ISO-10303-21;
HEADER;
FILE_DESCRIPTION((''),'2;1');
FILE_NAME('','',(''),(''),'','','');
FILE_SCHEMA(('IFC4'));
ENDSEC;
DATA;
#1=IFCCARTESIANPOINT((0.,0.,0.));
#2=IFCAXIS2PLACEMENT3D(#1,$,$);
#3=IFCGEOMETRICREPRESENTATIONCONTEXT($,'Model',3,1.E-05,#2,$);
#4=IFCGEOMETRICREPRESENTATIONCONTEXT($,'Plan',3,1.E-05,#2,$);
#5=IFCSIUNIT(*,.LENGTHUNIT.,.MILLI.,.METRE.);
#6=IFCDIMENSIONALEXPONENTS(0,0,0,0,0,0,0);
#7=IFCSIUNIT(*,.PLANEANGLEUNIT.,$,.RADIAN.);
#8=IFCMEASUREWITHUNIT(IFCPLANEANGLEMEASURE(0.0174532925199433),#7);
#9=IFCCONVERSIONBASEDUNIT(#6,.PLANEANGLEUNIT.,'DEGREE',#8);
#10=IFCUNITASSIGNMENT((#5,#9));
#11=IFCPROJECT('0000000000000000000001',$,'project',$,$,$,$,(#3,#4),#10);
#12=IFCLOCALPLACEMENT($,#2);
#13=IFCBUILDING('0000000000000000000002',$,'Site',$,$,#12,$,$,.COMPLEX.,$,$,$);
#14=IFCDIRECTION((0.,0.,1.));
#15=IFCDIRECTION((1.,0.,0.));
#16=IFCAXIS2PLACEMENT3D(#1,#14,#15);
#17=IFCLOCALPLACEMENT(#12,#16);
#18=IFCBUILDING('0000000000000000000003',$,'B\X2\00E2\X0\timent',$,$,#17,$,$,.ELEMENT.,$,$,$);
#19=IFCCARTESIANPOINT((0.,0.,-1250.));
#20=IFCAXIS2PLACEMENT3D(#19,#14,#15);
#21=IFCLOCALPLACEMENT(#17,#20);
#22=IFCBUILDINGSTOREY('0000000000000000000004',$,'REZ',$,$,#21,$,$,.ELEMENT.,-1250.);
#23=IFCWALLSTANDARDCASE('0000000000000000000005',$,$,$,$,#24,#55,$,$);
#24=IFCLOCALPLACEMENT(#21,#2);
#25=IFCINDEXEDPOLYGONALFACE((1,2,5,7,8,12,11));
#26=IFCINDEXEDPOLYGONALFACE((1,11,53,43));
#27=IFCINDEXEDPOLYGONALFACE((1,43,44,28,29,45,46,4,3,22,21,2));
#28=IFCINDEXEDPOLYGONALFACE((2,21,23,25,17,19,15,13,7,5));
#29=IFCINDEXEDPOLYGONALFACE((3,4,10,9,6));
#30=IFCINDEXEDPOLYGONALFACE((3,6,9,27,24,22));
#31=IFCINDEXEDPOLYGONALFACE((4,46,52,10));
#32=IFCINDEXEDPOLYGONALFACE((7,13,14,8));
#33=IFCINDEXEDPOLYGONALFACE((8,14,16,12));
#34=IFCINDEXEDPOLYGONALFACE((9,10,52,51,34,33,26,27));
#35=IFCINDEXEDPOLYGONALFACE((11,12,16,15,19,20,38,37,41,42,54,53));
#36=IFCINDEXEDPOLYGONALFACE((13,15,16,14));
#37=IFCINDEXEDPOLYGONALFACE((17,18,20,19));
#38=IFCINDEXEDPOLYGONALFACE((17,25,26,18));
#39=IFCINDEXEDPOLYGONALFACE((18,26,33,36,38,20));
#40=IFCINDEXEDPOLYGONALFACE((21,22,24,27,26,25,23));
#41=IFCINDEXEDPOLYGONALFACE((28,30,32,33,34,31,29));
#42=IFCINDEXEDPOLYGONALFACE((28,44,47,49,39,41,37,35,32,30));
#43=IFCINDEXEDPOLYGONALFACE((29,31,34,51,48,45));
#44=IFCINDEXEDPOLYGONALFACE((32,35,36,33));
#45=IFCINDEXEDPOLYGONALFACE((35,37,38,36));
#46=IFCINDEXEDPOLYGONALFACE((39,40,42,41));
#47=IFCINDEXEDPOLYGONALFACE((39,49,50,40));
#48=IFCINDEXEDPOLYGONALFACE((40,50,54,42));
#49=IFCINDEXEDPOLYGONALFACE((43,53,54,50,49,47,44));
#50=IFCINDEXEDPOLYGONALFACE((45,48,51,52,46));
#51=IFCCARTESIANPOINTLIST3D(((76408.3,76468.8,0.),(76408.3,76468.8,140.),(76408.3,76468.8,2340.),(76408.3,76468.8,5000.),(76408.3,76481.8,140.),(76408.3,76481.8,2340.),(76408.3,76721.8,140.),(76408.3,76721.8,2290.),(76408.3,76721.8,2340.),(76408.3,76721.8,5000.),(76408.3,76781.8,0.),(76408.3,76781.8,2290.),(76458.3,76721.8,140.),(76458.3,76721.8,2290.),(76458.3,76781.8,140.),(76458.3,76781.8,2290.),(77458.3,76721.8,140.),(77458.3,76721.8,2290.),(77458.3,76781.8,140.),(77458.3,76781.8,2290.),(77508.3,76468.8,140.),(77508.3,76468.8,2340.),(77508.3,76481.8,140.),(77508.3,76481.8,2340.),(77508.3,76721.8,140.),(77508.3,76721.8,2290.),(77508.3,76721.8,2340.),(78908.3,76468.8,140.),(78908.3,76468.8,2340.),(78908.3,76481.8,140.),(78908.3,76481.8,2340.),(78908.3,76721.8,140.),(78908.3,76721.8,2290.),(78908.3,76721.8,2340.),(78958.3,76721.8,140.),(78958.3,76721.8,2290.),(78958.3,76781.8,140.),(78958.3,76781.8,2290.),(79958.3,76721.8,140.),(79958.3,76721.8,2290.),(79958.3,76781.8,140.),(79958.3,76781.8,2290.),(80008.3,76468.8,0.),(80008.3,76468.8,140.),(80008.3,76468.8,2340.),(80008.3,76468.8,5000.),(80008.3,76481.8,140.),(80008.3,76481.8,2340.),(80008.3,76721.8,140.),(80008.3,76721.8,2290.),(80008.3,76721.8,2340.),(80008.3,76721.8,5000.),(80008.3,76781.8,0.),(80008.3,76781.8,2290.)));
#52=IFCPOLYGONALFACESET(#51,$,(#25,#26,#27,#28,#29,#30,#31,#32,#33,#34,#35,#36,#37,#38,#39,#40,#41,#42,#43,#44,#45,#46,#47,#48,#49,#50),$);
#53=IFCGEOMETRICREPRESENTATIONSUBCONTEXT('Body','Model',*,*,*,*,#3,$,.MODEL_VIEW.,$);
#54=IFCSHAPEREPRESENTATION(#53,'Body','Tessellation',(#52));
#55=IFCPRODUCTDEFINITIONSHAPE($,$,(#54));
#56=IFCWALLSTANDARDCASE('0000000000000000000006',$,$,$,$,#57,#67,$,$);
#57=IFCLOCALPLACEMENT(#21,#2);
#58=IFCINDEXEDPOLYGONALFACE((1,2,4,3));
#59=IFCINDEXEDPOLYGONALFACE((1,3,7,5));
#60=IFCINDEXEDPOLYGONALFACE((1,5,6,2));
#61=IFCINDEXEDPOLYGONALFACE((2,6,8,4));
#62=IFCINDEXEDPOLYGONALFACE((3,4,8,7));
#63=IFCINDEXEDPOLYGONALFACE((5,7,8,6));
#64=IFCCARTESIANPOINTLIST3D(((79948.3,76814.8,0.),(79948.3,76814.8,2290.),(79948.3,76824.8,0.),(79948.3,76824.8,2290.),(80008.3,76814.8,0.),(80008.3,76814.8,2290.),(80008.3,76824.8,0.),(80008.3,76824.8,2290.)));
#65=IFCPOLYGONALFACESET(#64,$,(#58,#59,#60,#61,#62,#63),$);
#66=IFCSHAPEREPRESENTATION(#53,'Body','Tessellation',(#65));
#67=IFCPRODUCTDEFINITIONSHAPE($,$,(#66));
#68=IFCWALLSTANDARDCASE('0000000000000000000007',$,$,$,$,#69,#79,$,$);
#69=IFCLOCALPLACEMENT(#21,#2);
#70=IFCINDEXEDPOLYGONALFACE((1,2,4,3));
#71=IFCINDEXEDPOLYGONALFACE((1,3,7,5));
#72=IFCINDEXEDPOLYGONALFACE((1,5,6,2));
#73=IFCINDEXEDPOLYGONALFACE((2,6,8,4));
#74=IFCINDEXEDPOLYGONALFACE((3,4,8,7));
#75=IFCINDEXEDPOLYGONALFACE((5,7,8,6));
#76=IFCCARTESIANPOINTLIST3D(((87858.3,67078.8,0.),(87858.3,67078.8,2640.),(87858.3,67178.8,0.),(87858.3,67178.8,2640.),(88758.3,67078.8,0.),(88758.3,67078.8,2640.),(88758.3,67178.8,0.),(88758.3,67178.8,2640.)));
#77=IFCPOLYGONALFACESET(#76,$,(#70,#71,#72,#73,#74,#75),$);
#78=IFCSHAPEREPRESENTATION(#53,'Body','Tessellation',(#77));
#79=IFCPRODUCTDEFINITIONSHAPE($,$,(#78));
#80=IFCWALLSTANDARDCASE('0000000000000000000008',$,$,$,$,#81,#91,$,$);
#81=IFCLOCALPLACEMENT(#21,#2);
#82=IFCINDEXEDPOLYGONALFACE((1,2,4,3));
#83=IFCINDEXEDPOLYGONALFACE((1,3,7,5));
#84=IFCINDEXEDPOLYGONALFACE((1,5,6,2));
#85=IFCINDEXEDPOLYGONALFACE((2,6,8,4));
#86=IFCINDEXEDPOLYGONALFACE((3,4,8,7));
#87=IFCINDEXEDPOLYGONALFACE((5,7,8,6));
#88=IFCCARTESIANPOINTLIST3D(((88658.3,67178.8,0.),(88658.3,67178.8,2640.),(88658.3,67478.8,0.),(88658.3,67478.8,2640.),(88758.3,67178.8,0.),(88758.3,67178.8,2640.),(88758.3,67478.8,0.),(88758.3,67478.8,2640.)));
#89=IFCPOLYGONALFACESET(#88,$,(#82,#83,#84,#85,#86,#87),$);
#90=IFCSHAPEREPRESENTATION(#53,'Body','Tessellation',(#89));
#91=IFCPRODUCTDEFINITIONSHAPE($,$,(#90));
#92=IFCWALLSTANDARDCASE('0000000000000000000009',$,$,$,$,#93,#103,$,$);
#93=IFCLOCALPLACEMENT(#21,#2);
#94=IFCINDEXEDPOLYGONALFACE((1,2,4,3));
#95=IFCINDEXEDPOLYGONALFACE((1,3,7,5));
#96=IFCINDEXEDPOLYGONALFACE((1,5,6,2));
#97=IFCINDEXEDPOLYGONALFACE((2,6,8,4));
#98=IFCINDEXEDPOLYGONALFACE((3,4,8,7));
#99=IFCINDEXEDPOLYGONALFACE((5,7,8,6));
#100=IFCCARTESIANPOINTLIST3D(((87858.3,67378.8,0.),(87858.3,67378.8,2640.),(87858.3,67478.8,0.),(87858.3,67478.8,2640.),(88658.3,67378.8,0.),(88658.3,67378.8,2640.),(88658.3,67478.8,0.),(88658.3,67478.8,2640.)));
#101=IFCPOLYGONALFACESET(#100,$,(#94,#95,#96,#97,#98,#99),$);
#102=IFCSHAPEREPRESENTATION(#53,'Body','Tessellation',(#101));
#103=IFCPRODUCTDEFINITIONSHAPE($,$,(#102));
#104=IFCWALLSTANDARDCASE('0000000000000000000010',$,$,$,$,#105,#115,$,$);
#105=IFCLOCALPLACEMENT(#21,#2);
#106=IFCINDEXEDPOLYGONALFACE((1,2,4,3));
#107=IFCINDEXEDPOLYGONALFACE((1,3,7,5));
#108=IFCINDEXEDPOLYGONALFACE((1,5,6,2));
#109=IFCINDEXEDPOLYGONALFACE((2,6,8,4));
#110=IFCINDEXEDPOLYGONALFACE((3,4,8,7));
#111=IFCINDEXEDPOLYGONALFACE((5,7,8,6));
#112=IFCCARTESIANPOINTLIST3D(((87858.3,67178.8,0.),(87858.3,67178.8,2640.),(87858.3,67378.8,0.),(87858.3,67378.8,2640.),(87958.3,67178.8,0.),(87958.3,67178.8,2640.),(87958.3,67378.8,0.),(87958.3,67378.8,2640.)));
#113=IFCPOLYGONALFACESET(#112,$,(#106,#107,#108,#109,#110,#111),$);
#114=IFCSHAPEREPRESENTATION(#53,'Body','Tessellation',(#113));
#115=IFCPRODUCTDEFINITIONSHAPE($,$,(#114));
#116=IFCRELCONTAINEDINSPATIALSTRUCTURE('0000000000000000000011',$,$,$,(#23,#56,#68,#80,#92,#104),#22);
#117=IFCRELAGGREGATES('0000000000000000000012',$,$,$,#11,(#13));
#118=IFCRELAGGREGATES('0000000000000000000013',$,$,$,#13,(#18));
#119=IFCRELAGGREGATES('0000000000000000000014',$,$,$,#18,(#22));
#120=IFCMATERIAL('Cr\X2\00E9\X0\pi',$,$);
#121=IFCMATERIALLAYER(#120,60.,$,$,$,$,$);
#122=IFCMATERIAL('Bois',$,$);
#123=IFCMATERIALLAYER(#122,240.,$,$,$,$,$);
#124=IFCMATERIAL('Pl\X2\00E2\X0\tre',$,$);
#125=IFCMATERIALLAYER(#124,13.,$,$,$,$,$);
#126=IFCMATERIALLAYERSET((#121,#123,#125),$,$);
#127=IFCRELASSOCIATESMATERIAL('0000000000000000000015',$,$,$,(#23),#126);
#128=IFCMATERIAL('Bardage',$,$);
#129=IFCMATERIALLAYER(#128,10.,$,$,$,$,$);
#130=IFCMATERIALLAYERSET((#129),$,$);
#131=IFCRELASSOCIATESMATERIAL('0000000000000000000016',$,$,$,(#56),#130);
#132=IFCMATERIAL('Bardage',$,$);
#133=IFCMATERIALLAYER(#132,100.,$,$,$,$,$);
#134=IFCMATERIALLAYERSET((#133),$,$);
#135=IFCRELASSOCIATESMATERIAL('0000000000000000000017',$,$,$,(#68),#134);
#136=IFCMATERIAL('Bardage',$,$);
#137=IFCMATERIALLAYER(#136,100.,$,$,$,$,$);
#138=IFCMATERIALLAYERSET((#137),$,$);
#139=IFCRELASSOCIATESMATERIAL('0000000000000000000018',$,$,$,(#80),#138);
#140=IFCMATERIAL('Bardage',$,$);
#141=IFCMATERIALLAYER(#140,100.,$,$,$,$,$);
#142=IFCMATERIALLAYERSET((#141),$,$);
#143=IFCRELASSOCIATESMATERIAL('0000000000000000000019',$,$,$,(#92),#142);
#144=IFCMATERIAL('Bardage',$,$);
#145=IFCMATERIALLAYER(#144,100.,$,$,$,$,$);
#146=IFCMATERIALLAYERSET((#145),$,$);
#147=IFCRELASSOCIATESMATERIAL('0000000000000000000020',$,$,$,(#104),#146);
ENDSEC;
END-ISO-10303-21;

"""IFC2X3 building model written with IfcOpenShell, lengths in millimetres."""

from ifc_helpers import new_model, entity, si_unit, converted_unit, frame, frame_2d, origin, origin_with_axes, place, context, subcontext, project, spatial, polyline, rectangle, extrude, clip, bounded_halfspace, material, layer, layer_set, layer_usage, element, save


model = new_model("IFC2X3")

# Units and contexts
model_context = context("Model", 3, precision=1e-05, world=origin())
plan_context = context("Plan", 3, precision=1e-05, world=origin())
body_context = subcontext(model_context, "Body", "Model", "MODEL_VIEW")
ifc_project = project(units=[si_unit("LENGTHUNIT", "METRE", prefix="MILLI"), converted_unit("PLANEANGLEUNIT", "DEGREE", entity("IfcPlaneAngleMeasure", 0.0174532925199433), si_unit("PLANEANGLEUNIT", "RADIAN"), dimensions=[0, 0, 0, 0, 0, 0, 0])], contexts=[model_context, plan_context])

# Buildings, storey
building_1_placement = place(None, origin())
building_1 = spatial("IfcBuilding", under=ifc_project, at=building_1_placement, Name="Site", CompositionType="COMPLEX")
building_2_placement = place(building_1_placement, origin_with_axes())
building_2 = spatial("IfcBuilding", under=building_1, at=building_2_placement, Name="Bâtiment", CompositionType="ELEMENT")
storey_placement = place(building_2_placement, frame((0.0, 0.0, -1250.0), z_axis=(0.0, 0.0, 1.0), x_axis=(1.0, 0.0, 0.0)))
storey = spatial("IfcBuildingStorey", under=building_2, at=storey_placement, Name="REZ", CompositionType="ELEMENT", Elevation=-1250.0)

# Wall, openings
ifc_material_1 = material(Name="Crépi")
ifc_layer_1 = layer(ifc_material_1, 60.0)
ifc_material_2 = material(Name="Bois")
ifc_layer_2 = layer(ifc_material_2, 240.0)
ifc_material_3 = material(Name="Plâtre")
ifc_layer_3 = layer(ifc_material_3, 13.0)
ifc_layer_set_1 = layer_set([ifc_layer_1, ifc_layer_2, ifc_layer_3])
ifc_layer_usage_1 = layer_usage(ifc_layer_set_1, "AXIS2", "POSITIVE", 0.0)
wall_1_placement = place(storey_placement, frame((80008.3, 76781.8, 0.0), z_axis=(0.0, 0.0, 1.0), x_axis=(-1.0, 0.0, 0.0)))
wall_1 = element("IfcWallStandardCase", 1, at=wall_1_placement, inside=storey, material=ifc_layer_usage_1, context=body_context, shape_type="Clipping", body=[
    clip(clip(extrude(rectangle(XDim=3600.0, YDim=313.0, at=frame_2d((1800.0, 156.5), x_axis=(1.0, 0.0))), origin_with_axes(), (0.0, 0.0, 1.0), 5000.0), bounded_halfspace(frame((0.0, 0.0, 2290.0), z_axis=(0.0, 0.0, -1.0), x_axis=(1.0, 0.0, 0.0)), True, origin(), polyline([(0.0, 0.0), (3600.0, 0.0), (3600.0, 60.0), (0.0, 60.0), (0.0, 0.0)]))), bounded_halfspace(frame((0.0, 60.0, 5000.0), z_axis=(0.0, 0.0, -1.0), x_axis=(1.0, 0.0, 0.0)), True, origin(), polyline([(0.0, 60.0), (3600.0, 60.0), (3600.0, 313.0), (0.0, 313.0), (0.0, 60.0)]))),
])
opening_1_placement = place(wall_1_placement, frame((2550.0, 0.0, 140.0), z_axis=(0.0, 1.0, 0.0), x_axis=(0.0, 0.0, 1.0)))
element("IfcOpeningElement", 2, at=opening_1_placement, cuts=wall_1, ObjectType="Opening", context=body_context, shape_type="SweptSolid", body=[
    extrude(rectangle(XDim=2150.0, YDim=1000.0, at=frame_2d((1075.0, 500.0), x_axis=(1.0, 0.0))), origin_with_axes(), (0.0, 0.0, 1.0), 60.0),
    extrude(rectangle(XDim=2200.0, YDim=1100.0, at=frame_2d((1100.0, 550.0), x_axis=(1.0, 0.0))), frame((0.0, -50.0, 60.0), z_axis=(0.0, 0.0, 1.0), x_axis=(1.0, 0.0, 0.0)), (0.0, 0.0, 1.0), 240.0),
    extrude(rectangle(XDim=2200.0, YDim=1100.0, at=frame_2d((1100.0, 550.0), x_axis=(1.0, 0.0))), frame((0.0, -50.0, 300.0), z_axis=(0.0, 0.0, 1.0), x_axis=(1.0, 0.0, 0.0)), (0.0, 0.0, 1.0), 13.0),
])
opening_2_placement = place(wall_1_placement, frame((50.0, 0.0, 140.0), z_axis=(0.0, 1.0, 0.0), x_axis=(0.0, 0.0, 1.0)))
element("IfcOpeningElement", 3, at=opening_2_placement, cuts=wall_1, ObjectType="Opening", context=body_context, shape_type="SweptSolid", body=[
    extrude(rectangle(XDim=2150.0, YDim=1000.0, at=frame_2d((1075.0, 500.0), x_axis=(1.0, 0.0))), origin_with_axes(), (0.0, 0.0, 1.0), 60.0),
    extrude(rectangle(XDim=2200.0, YDim=1100.0, at=frame_2d((1100.0, 550.0), x_axis=(1.0, 0.0))), frame((0.0, -50.0, 60.0), z_axis=(0.0, 0.0, 1.0), x_axis=(1.0, 0.0, 0.0)), (0.0, 0.0, 1.0), 240.0),
    extrude(rectangle(XDim=2200.0, YDim=1100.0, at=frame_2d((1100.0, 550.0), x_axis=(1.0, 0.0))), frame((0.0, -50.0, 300.0), z_axis=(0.0, 0.0, 1.0), x_axis=(1.0, 0.0, 0.0)), (0.0, 0.0, 1.0), 13.0),
])

# Walls
ifc_material_4 = material(Name="Bardage")
ifc_layer_4 = layer(ifc_material_4, 10.0)
ifc_layer_set_2 = layer_set([ifc_layer_4])
ifc_layer_usage_2 = layer_usage(ifc_layer_set_2, "AXIS2", "POSITIVE", 0.0)
wall_2_placement = place(storey_placement, frame((80008.3, 76824.8, 0.0), z_axis=(0.0, 0.0, 1.0), x_axis=(-1.0, 0.0, 0.0)))
element("IfcWallStandardCase", 4, at=wall_2_placement, inside=storey, material=ifc_layer_usage_2, context=body_context, shape_type="SweptSolid", body=[
    extrude(rectangle(XDim=60.0, YDim=10.0, at=frame_2d((30.0, 5.0), x_axis=(1.0, 0.0))), origin_with_axes(), (0.0, 0.0, 1.0), 2290.0),
])
ifc_material_5 = material(Name="Bardage")
ifc_layer_5 = layer(ifc_material_5, 100.0)
ifc_layer_set_3 = layer_set([ifc_layer_5])
ifc_layer_usage_3 = layer_usage(ifc_layer_set_3, "AXIS2", "POSITIVE", 0.0)
wall_3_placement = place(storey_placement, frame((87858.3, 67078.8, 0.0), z_axis=(0.0, 0.0, 1.0), x_axis=(1.0, 0.0, 0.0)))
element("IfcWallStandardCase", 5, at=wall_3_placement, inside=storey, material=ifc_layer_usage_3, context=body_context, shape_type="SweptSolid", body=[
    extrude(rectangle(XDim=900.0, YDim=100.0, at=frame_2d((450.0, 50.0), x_axis=(1.0, 0.0))), origin_with_axes(), (0.0, 0.0, 1.0), 2640.0),
])
ifc_material_6 = material(Name="Bardage")
ifc_layer_6 = layer(ifc_material_6, 100.0)
ifc_layer_set_4 = layer_set([ifc_layer_6])
ifc_layer_usage_4 = layer_usage(ifc_layer_set_4, "AXIS2", "POSITIVE", 0.0)
wall_4_placement = place(storey_placement, frame((88758.3, 67178.8, 0.0), z_axis=(0.0, 0.0, 1.0), x_axis=(0.0, 1.0, 0.0)))
element("IfcWallStandardCase", 6, at=wall_4_placement, inside=storey, material=ifc_layer_usage_4, context=body_context, shape_type="SweptSolid", body=[
    extrude(rectangle(XDim=300.0, YDim=100.0, at=frame_2d((150.0, 50.0), x_axis=(1.0, 0.0))), origin_with_axes(), (0.0, 0.0, 1.0), 2640.0),
])
ifc_material_7 = material(Name="Bardage")
ifc_layer_7 = layer(ifc_material_7, 100.0)
ifc_layer_set_5 = layer_set([ifc_layer_7])
ifc_layer_usage_5 = layer_usage(ifc_layer_set_5, "AXIS2", "POSITIVE", 0.0)
wall_5_placement = place(storey_placement, frame((88658.3, 67478.8, 0.0), z_axis=(0.0, 0.0, 1.0), x_axis=(-1.0, 0.0, 0.0)))
element("IfcWallStandardCase", 7, at=wall_5_placement, inside=storey, material=ifc_layer_usage_5, context=body_context, shape_type="SweptSolid", body=[
    extrude(rectangle(XDim=800.0, YDim=100.0, at=frame_2d((400.0, 50.0), x_axis=(1.0, 0.0))), origin_with_axes(), (0.0, 0.0, 1.0), 2640.0),
])
ifc_material_8 = material(Name="Bardage")
ifc_layer_8 = layer(ifc_material_8, 100.0)
ifc_layer_set_6 = layer_set([ifc_layer_8])
ifc_layer_usage_6 = layer_usage(ifc_layer_set_6, "AXIS2", "POSITIVE", 0.0)
wall_6_placement = place(storey_placement, frame((87858.3, 67378.8, 0.0), z_axis=(0.0, 0.0, 1.0), x_axis=(0.0, -1.0, 0.0)))
element("IfcWallStandardCase", 8, at=wall_6_placement, inside=storey, material=ifc_layer_usage_6, context=body_context, shape_type="SweptSolid", body=[
    extrude(rectangle(XDim=200.0, YDim=100.0, at=frame_2d((100.0, 50.0), x_axis=(1.0, 0.0))), origin_with_axes(), (0.0, 0.0, 1.0), 2640.0),
])

save(model, "model.ifc")
